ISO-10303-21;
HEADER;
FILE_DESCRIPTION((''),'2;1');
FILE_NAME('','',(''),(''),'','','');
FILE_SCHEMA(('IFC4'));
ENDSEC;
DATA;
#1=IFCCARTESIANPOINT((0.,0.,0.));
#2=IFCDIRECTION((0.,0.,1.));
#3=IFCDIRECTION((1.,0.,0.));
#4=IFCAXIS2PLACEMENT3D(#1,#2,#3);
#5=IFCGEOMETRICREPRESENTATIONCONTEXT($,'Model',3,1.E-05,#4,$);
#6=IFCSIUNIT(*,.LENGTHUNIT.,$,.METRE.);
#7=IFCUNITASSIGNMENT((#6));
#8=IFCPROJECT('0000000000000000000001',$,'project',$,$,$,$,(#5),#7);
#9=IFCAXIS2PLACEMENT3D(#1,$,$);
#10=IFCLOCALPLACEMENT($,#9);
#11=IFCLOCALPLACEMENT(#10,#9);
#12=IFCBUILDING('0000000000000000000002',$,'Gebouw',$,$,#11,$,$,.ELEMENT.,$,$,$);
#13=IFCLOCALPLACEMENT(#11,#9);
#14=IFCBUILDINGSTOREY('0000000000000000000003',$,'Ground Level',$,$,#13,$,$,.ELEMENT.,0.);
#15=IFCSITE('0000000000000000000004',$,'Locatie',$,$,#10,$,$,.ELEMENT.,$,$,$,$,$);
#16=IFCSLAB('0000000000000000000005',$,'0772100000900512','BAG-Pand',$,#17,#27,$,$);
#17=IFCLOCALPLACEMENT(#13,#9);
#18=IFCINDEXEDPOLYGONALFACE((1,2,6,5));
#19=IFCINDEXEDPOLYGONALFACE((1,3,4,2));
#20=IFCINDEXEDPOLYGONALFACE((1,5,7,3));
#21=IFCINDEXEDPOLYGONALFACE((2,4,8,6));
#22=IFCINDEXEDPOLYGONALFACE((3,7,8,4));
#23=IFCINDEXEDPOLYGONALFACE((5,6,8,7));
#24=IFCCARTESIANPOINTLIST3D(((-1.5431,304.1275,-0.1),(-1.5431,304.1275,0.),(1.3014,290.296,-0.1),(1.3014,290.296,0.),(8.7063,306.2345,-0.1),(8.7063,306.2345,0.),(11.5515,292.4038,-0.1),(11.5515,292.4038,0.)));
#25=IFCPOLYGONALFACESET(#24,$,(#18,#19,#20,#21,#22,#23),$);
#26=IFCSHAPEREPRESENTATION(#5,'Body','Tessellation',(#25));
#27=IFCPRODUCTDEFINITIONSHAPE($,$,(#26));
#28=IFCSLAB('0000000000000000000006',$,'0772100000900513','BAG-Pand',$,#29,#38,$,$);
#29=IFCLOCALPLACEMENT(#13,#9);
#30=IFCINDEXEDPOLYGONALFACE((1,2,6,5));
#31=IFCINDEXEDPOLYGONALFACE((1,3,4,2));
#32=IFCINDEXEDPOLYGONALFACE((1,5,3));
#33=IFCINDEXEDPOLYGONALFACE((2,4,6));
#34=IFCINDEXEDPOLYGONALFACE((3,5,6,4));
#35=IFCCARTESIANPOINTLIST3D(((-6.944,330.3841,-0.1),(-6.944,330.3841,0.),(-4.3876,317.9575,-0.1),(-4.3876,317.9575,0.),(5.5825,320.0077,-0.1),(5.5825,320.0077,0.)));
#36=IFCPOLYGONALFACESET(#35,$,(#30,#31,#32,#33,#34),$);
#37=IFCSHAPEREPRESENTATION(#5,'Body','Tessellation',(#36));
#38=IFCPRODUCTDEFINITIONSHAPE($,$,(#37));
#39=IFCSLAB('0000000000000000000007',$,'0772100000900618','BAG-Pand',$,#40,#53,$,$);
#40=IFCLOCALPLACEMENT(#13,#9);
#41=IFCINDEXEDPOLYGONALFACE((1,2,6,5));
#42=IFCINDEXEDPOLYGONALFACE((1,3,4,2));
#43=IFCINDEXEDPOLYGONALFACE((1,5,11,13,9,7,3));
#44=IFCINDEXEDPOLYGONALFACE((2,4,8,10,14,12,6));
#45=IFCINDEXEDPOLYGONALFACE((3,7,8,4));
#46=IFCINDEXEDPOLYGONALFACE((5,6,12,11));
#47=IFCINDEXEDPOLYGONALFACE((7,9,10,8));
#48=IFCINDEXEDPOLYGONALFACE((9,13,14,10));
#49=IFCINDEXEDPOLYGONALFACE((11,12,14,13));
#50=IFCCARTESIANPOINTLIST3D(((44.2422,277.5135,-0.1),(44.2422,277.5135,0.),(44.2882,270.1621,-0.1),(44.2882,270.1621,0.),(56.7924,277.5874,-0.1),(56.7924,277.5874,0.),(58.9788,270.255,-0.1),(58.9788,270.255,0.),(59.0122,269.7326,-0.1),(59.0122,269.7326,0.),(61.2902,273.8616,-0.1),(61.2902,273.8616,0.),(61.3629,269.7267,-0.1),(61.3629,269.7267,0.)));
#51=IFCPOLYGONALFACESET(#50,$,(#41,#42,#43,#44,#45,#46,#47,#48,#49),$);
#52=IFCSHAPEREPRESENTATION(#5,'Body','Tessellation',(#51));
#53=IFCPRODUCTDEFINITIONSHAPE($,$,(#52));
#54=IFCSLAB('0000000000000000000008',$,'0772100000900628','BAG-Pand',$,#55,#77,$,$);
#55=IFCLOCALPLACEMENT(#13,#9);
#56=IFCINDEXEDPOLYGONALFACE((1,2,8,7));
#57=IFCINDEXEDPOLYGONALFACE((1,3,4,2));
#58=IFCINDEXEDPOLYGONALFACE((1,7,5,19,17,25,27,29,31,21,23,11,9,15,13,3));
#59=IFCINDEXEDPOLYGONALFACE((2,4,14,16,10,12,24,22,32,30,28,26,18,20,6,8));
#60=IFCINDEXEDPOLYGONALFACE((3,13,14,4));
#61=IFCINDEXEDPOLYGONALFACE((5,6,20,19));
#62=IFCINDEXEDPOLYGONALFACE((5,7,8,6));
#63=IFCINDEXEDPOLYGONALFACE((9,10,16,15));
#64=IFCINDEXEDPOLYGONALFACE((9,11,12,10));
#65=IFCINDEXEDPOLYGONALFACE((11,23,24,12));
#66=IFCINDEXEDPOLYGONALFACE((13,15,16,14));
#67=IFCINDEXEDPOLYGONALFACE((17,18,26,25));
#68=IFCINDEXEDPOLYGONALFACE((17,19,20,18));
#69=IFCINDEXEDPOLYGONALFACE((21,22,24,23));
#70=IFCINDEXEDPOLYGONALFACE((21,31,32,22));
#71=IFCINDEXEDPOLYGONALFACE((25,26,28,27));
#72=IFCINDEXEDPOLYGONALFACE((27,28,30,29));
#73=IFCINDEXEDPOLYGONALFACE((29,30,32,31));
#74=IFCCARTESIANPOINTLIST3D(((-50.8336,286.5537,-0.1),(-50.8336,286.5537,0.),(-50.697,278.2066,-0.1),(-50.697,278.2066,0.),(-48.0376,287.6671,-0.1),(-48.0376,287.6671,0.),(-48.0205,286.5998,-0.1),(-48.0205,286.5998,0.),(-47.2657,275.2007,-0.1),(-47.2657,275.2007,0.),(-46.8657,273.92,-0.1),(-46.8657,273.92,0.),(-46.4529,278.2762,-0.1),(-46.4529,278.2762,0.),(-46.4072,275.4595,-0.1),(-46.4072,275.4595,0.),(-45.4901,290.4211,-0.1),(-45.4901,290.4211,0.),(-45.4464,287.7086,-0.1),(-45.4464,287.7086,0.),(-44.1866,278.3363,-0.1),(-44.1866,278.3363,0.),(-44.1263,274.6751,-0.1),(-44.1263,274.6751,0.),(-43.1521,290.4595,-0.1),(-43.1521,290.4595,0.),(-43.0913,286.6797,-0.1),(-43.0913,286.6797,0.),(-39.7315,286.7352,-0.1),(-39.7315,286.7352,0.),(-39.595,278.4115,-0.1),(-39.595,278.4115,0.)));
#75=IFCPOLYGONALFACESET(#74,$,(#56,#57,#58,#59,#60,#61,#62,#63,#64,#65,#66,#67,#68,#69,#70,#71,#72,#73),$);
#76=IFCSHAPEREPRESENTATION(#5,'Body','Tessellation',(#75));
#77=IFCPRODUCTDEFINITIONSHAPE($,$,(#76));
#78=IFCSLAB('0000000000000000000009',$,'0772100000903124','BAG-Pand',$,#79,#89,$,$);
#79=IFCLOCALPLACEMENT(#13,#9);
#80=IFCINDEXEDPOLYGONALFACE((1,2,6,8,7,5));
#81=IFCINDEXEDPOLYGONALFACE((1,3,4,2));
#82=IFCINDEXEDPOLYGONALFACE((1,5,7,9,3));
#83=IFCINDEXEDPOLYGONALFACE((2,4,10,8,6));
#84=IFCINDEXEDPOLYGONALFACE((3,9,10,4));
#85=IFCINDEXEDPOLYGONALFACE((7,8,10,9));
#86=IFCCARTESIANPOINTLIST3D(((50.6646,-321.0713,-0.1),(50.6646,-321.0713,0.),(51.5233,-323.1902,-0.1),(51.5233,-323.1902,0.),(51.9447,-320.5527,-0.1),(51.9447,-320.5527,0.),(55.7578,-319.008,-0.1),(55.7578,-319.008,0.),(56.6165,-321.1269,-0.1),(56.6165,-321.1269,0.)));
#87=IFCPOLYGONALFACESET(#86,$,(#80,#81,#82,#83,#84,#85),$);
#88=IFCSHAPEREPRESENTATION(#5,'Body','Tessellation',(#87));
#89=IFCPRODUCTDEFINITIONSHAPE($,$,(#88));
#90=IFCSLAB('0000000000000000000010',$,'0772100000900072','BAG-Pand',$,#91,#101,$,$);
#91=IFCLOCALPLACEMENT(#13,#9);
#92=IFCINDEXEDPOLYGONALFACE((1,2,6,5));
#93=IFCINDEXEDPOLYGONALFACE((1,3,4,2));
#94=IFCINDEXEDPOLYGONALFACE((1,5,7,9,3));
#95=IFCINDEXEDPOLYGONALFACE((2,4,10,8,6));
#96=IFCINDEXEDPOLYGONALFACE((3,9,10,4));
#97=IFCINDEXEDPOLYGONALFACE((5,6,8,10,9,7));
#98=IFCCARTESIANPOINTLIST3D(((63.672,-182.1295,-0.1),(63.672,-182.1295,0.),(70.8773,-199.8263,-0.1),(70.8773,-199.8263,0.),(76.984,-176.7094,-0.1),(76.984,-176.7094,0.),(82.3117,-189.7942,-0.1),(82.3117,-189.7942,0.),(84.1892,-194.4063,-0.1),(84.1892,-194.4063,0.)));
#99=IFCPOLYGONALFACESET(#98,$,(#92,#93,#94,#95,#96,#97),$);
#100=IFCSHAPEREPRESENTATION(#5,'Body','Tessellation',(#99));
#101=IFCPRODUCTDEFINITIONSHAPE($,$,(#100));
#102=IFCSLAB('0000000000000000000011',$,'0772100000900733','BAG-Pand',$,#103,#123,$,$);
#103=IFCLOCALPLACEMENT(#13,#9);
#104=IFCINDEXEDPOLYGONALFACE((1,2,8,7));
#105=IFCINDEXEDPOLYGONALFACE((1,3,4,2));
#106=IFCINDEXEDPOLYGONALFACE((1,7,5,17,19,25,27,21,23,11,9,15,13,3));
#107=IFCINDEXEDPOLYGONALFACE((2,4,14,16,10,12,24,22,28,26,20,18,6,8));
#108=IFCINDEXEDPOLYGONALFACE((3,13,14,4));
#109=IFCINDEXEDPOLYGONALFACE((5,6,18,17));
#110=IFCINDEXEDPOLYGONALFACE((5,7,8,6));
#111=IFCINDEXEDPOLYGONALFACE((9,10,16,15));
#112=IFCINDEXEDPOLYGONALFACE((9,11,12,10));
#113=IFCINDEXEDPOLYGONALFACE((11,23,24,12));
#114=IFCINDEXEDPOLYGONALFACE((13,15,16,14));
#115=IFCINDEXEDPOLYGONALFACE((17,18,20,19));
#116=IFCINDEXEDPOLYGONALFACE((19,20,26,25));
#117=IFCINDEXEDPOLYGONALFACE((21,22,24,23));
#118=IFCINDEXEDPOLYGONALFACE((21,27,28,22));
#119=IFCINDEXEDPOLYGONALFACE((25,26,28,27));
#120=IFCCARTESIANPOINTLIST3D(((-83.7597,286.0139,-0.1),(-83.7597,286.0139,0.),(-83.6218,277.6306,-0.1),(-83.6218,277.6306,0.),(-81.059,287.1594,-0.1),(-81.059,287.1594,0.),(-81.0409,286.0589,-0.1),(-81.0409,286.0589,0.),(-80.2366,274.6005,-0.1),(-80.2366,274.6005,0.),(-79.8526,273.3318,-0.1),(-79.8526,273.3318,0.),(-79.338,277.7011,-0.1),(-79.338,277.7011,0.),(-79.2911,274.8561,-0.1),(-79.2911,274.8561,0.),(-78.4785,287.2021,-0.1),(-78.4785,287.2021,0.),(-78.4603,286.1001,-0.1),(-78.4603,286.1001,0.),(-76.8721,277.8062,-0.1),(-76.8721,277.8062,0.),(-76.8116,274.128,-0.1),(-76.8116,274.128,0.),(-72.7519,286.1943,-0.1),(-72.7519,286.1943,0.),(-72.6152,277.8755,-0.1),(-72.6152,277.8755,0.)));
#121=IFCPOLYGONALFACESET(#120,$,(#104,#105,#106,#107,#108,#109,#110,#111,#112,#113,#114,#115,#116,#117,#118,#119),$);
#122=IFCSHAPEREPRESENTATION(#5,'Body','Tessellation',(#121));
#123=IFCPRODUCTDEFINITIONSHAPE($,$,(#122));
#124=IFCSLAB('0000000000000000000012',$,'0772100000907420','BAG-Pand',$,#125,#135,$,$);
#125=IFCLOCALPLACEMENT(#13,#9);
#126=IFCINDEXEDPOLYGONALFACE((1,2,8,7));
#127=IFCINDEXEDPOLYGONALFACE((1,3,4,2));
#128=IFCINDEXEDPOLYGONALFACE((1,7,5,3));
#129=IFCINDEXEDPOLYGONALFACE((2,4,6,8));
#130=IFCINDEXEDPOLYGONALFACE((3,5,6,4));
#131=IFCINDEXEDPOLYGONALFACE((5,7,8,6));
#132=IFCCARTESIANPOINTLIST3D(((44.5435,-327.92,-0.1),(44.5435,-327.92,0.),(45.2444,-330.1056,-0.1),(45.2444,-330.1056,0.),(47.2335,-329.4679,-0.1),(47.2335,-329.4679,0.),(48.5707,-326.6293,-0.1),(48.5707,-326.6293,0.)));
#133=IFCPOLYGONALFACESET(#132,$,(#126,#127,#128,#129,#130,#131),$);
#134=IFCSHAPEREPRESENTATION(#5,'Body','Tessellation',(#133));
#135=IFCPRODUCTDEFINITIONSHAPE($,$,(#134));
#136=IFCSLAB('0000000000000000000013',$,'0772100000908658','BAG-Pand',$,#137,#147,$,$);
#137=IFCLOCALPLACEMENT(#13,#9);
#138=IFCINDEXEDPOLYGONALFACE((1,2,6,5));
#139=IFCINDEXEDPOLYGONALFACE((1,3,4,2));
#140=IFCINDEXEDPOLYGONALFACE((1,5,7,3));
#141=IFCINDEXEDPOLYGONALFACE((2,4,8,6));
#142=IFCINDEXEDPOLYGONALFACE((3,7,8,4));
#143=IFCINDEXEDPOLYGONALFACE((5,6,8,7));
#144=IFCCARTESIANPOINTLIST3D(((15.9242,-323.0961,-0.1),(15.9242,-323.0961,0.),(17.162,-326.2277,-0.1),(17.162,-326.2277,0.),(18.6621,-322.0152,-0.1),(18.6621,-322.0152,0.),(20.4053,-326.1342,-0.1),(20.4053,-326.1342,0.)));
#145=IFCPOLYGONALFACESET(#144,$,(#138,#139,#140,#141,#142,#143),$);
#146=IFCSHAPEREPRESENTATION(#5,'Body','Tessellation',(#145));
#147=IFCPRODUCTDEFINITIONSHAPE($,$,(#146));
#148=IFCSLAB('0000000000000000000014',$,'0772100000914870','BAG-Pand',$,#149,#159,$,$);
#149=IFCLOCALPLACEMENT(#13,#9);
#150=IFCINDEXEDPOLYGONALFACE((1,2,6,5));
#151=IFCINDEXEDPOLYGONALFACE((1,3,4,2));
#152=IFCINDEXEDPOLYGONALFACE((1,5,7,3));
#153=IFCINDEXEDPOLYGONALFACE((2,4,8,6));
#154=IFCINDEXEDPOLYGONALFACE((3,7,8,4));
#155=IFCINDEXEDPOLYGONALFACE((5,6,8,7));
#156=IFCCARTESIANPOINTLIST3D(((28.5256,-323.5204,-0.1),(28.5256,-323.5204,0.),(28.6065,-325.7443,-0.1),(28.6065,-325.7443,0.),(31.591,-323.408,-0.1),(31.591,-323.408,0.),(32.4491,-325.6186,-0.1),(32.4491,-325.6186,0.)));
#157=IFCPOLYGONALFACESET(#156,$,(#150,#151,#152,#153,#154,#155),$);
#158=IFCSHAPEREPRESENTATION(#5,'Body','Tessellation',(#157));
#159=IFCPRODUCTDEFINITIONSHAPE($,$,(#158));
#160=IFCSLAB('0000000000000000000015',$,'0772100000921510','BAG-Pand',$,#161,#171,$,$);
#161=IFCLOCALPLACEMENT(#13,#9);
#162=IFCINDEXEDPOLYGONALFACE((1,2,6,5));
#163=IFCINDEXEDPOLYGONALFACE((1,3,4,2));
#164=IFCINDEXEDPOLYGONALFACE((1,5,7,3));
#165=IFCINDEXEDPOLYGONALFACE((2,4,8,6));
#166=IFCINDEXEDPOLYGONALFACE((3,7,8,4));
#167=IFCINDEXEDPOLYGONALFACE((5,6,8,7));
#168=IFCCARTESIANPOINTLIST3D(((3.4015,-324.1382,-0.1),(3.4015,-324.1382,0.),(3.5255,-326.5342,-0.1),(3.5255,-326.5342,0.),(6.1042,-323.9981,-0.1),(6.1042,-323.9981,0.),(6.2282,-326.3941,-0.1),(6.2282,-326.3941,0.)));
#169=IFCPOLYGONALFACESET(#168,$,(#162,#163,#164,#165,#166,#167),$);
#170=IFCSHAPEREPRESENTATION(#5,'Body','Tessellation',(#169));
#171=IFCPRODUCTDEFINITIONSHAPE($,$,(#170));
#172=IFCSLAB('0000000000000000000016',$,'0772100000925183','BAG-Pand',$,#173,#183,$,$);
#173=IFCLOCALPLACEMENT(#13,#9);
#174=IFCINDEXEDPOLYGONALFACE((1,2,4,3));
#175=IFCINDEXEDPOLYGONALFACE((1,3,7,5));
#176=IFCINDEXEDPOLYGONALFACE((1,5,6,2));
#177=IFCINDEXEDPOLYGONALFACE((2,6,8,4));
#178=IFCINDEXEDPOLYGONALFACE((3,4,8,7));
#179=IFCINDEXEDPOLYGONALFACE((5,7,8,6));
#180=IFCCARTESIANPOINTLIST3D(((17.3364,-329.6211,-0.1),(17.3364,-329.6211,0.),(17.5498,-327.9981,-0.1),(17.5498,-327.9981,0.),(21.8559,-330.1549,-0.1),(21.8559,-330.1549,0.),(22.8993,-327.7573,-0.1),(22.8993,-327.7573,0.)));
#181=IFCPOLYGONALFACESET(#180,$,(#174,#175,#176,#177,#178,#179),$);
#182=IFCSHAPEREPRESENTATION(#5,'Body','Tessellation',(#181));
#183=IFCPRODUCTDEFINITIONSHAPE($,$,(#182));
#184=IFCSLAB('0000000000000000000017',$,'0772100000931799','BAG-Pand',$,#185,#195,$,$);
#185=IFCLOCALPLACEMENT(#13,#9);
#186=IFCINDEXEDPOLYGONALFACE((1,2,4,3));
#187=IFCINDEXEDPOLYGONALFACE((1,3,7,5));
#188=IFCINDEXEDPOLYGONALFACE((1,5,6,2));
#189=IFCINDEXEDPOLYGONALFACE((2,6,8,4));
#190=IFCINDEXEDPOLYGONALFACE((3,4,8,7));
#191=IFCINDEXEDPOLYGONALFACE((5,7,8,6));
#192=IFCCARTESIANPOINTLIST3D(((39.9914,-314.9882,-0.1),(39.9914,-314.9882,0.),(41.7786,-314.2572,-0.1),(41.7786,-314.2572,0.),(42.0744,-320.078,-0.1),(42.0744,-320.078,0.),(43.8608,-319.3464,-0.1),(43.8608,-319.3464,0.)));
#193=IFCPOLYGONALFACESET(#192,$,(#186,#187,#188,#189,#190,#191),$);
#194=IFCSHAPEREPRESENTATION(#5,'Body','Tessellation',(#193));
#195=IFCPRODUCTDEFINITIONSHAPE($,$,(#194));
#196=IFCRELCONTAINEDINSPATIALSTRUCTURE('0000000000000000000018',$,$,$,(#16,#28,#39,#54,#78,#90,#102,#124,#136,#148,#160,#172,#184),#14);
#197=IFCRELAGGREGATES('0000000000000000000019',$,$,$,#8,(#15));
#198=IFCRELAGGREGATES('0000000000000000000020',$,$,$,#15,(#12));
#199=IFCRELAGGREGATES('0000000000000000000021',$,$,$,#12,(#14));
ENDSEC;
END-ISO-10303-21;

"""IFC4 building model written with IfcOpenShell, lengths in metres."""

from ifc_helpers import new_model, si_unit, frame, origin, origin_with_axes, place, context, project, spatial, polyline, outline, extrude, element, save


model = new_model("IFC4")

# Units and contexts
model_context = context("Model", 3, precision=1e-05, world=origin_with_axes())
ifc_project = project(units=[si_unit("LENGTHUNIT", "METRE")], contexts=[model_context])

# Site, building, storey
site_placement = place(None, origin())
site = spatial("IfcSite", under=ifc_project, at=site_placement, Name="Locatie", CompositionType="ELEMENT")
building_placement = place(site_placement, origin())
building = spatial("IfcBuilding", under=site, at=building_placement, Name="Gebouw", CompositionType="ELEMENT")
storey_placement = place(building_placement, origin())
storey = spatial("IfcBuildingStorey", under=building, at=storey_placement, Name="Ground Level", CompositionType="ELEMENT", Elevation=0.0)

# Slabs
slab_1_placement = place(storey_placement, origin())
element("IfcSlab", 1, at=slab_1_placement, inside=storey, Name="0772100000900512", Description="BAG-Pand", context=model_context, shape_type="SweptSolid", body=[
    extrude(outline(polyline([(-1.5431, 304.1275), (8.7063, 306.2345), (11.5515, 292.4038), (1.3014, 290.296), (-1.5431, 304.1275)])), frame((0.0, 0.0, -0.1), z_axis=(0.0, 0.0, 1.0), x_axis=(1.0, 0.0, 0.0)), (0.0, 0.0, 1.0), 0.1),
])
slab_2_placement = place(storey_placement, origin())
element("IfcSlab", 2, at=slab_2_placement, inside=storey, Name="0772100000900513", Description="BAG-Pand", context=model_context, shape_type="SweptSolid", body=[
    extrude(outline(polyline([(-4.3876, 317.9575), (-6.944, 330.3841), (5.5825, 320.0077), (-4.3876, 317.9575)])), frame((0.0, 0.0, -0.1), z_axis=(0.0, 0.0, 1.0), x_axis=(1.0, 0.0, 0.0)), (0.0, 0.0, 1.0), 0.1),
])
slab_3_placement = place(storey_placement, origin())
element("IfcSlab", 3, at=slab_3_placement, inside=storey, Name="0772100000900618", Description="BAG-Pand", context=model_context, shape_type="SweptSolid", body=[
    extrude(outline(polyline([(61.3629, 269.7267), (59.0122, 269.7326), (58.9788, 270.255), (44.2882, 270.1621), (44.2422, 277.5135), (56.7924, 277.5874), (61.2902, 273.8616), (61.3629, 269.7267)])), frame((0.0, 0.0, -0.1), z_axis=(0.0, 0.0, 1.0), x_axis=(1.0, 0.0, 0.0)), (0.0, 0.0, 1.0), 0.1),
])
slab_4_placement = place(storey_placement, origin())
element("IfcSlab", 4, at=slab_4_placement, inside=storey, Name="0772100000900628", Description="BAG-Pand", context=model_context, shape_type="SweptSolid", body=[
    extrude(outline(polyline([(-48.0376, 287.6671), (-45.4464, 287.7086), (-45.4901, 290.4211), (-43.1521, 290.4595), (-43.0913, 286.6797), (-39.7315, 286.7352), (-39.595, 278.4115), (-44.1866, 278.3363), (-44.1263, 274.6751), (-46.8657, 273.92), (-47.2657, 275.2007), (-46.4072, 275.4595), (-46.4529, 278.2762), (-50.697, 278.2066), (-50.8336, 286.5537), (-48.0205, 286.5998), (-48.0376, 287.6671)])), frame((0.0, 0.0, -0.1), z_axis=(0.0, 0.0, 1.0), x_axis=(1.0, 0.0, 0.0)), (0.0, 0.0, 1.0), 0.1),
])
slab_5_placement = place(storey_placement, origin())
element("IfcSlab", 5, at=slab_5_placement, inside=storey, Name="0772100000903124", Description="BAG-Pand", context=model_context, shape_type="SweptSolid", body=[
    extrude(outline(polyline([(50.6646, -321.0713), (51.9447, -320.5527), (55.7578, -319.008), (56.6165, -321.1269), (51.5233, -323.1902), (50.6646, -321.0713)])), frame((0.0, 0.0, -0.1), z_axis=(0.0, 0.0, 1.0), x_axis=(1.0, 0.0, 0.0)), (0.0, 0.0, 1.0), 0.1),
])
slab_6_placement = place(storey_placement, origin())
element("IfcSlab", 6, at=slab_6_placement, inside=storey, Name="0772100000900072", Description="BAG-Pand", context=model_context, shape_type="SweptSolid", body=[
    extrude(outline(polyline([(63.672, -182.1295), (76.984, -176.7094), (82.3117, -189.7942), (84.1892, -194.4063), (70.8773, -199.8263), (63.672, -182.1295)])), frame((0.0, 0.0, -0.1), z_axis=(0.0, 0.0, 1.0), x_axis=(1.0, 0.0, 0.0)), (0.0, 0.0, 1.0), 0.1),
])
slab_7_placement = place(storey_placement, origin())
element("IfcSlab", 7, at=slab_7_placement, inside=storey, Name="0772100000900733", Description="BAG-Pand", context=model_context, shape_type="SweptSolid", body=[
    extrude(outline(polyline([(-80.2366, 274.6005), (-79.2911, 274.8561), (-79.338, 277.7011), (-83.6218, 277.6306), (-83.7597, 286.0139), (-81.0409, 286.0589), (-81.059, 287.1594), (-78.4785, 287.2021), (-78.4603, 286.1001), (-72.7519, 286.1943), (-72.6152, 277.8755), (-76.8721, 277.8062), (-76.8116, 274.128), (-79.8526, 273.3318), (-80.2366, 274.6005)])), frame((0.0, 0.0, -0.1), z_axis=(0.0, 0.0, 1.0), x_axis=(1.0, 0.0, 0.0)), (0.0, 0.0, 1.0), 0.1),
])
slab_8_placement = place(storey_placement, origin())
element("IfcSlab", 8, at=slab_8_placement, inside=storey, Name="0772100000907420", Description="BAG-Pand", context=model_context, shape_type="SweptSolid", body=[
    extrude(outline(polyline([(44.5435, -327.92), (48.5707, -326.6293), (47.2335, -329.4679), (45.2444, -330.1056), (44.5435, -327.92)])), frame((0.0, 0.0, -0.1), z_axis=(0.0, 0.0, 1.0), x_axis=(1.0, 0.0, 0.0)), (0.0, 0.0, 1.0), 0.1),
])
slab_9_placement = place(storey_placement, origin())
element("IfcSlab", 9, at=slab_9_placement, inside=storey, Name="0772100000908658", Description="BAG-Pand", context=model_context, shape_type="SweptSolid", body=[
    extrude(outline(polyline([(15.9242, -323.0961), (18.6621, -322.0152), (20.4053, -326.1342), (17.162, -326.2277), (15.9242, -323.0961)])), frame((0.0, 0.0, -0.1), z_axis=(0.0, 0.0, 1.0), x_axis=(1.0, 0.0, 0.0)), (0.0, 0.0, 1.0), 0.1),
])
slab_10_placement = place(storey_placement, origin())
element("IfcSlab", 10, at=slab_10_placement, inside=storey, Name="0772100000914870", Description="BAG-Pand", context=model_context, shape_type="SweptSolid", body=[
    extrude(outline(polyline([(28.5256, -323.5204), (31.591, -323.408), (32.4491, -325.6186), (28.6065, -325.7443), (28.5256, -323.5204)])), frame((0.0, 0.0, -0.1), z_axis=(0.0, 0.0, 1.0), x_axis=(1.0, 0.0, 0.0)), (0.0, 0.0, 1.0), 0.1),
])
slab_11_placement = place(storey_placement, origin())
element("IfcSlab", 11, at=slab_11_placement, inside=storey, Name="0772100000921510", Description="BAG-Pand", context=model_context, shape_type="SweptSolid", body=[
    extrude(outline(polyline([(3.4015, -324.1382), (6.1042, -323.9981), (6.2282, -326.3941), (3.5255, -326.5342), (3.4015, -324.1382)])), frame((0.0, 0.0, -0.1), z_axis=(0.0, 0.0, 1.0), x_axis=(1.0, 0.0, 0.0)), (0.0, 0.0, 1.0), 0.1),
])
slab_12_placement = place(storey_placement, origin())
element("IfcSlab", 12, at=slab_12_placement, inside=storey, Name="0772100000925183", Description="BAG-Pand", context=model_context, shape_type="SweptSolid", body=[
    extrude(outline(polyline([(22.8993, -327.7573), (21.8559, -330.1549), (17.3364, -329.6211), (17.5498, -327.9981), (22.8993, -327.7573)])), frame((0.0, 0.0, -0.1), z_axis=(0.0, 0.0, 1.0), x_axis=(1.0, 0.0, 0.0)), (0.0, 0.0, 1.0), 0.1),
])
slab_13_placement = place(storey_placement, origin())
element("IfcSlab", 13, at=slab_13_placement, inside=storey, Name="0772100000931799", Description="BAG-Pand", context=model_context, shape_type="SweptSolid", body=[
    extrude(outline(polyline([(39.9914, -314.9882), (41.7786, -314.2572), (43.8608, -319.3464), (42.0744, -320.078), (39.9914, -314.9882)])), frame((0.0, 0.0, -0.1), z_axis=(0.0, 0.0, 1.0), x_axis=(1.0, 0.0, 0.0)), (0.0, 0.0, 1.0), 0.1),
])

save(model, "model.ifc")
